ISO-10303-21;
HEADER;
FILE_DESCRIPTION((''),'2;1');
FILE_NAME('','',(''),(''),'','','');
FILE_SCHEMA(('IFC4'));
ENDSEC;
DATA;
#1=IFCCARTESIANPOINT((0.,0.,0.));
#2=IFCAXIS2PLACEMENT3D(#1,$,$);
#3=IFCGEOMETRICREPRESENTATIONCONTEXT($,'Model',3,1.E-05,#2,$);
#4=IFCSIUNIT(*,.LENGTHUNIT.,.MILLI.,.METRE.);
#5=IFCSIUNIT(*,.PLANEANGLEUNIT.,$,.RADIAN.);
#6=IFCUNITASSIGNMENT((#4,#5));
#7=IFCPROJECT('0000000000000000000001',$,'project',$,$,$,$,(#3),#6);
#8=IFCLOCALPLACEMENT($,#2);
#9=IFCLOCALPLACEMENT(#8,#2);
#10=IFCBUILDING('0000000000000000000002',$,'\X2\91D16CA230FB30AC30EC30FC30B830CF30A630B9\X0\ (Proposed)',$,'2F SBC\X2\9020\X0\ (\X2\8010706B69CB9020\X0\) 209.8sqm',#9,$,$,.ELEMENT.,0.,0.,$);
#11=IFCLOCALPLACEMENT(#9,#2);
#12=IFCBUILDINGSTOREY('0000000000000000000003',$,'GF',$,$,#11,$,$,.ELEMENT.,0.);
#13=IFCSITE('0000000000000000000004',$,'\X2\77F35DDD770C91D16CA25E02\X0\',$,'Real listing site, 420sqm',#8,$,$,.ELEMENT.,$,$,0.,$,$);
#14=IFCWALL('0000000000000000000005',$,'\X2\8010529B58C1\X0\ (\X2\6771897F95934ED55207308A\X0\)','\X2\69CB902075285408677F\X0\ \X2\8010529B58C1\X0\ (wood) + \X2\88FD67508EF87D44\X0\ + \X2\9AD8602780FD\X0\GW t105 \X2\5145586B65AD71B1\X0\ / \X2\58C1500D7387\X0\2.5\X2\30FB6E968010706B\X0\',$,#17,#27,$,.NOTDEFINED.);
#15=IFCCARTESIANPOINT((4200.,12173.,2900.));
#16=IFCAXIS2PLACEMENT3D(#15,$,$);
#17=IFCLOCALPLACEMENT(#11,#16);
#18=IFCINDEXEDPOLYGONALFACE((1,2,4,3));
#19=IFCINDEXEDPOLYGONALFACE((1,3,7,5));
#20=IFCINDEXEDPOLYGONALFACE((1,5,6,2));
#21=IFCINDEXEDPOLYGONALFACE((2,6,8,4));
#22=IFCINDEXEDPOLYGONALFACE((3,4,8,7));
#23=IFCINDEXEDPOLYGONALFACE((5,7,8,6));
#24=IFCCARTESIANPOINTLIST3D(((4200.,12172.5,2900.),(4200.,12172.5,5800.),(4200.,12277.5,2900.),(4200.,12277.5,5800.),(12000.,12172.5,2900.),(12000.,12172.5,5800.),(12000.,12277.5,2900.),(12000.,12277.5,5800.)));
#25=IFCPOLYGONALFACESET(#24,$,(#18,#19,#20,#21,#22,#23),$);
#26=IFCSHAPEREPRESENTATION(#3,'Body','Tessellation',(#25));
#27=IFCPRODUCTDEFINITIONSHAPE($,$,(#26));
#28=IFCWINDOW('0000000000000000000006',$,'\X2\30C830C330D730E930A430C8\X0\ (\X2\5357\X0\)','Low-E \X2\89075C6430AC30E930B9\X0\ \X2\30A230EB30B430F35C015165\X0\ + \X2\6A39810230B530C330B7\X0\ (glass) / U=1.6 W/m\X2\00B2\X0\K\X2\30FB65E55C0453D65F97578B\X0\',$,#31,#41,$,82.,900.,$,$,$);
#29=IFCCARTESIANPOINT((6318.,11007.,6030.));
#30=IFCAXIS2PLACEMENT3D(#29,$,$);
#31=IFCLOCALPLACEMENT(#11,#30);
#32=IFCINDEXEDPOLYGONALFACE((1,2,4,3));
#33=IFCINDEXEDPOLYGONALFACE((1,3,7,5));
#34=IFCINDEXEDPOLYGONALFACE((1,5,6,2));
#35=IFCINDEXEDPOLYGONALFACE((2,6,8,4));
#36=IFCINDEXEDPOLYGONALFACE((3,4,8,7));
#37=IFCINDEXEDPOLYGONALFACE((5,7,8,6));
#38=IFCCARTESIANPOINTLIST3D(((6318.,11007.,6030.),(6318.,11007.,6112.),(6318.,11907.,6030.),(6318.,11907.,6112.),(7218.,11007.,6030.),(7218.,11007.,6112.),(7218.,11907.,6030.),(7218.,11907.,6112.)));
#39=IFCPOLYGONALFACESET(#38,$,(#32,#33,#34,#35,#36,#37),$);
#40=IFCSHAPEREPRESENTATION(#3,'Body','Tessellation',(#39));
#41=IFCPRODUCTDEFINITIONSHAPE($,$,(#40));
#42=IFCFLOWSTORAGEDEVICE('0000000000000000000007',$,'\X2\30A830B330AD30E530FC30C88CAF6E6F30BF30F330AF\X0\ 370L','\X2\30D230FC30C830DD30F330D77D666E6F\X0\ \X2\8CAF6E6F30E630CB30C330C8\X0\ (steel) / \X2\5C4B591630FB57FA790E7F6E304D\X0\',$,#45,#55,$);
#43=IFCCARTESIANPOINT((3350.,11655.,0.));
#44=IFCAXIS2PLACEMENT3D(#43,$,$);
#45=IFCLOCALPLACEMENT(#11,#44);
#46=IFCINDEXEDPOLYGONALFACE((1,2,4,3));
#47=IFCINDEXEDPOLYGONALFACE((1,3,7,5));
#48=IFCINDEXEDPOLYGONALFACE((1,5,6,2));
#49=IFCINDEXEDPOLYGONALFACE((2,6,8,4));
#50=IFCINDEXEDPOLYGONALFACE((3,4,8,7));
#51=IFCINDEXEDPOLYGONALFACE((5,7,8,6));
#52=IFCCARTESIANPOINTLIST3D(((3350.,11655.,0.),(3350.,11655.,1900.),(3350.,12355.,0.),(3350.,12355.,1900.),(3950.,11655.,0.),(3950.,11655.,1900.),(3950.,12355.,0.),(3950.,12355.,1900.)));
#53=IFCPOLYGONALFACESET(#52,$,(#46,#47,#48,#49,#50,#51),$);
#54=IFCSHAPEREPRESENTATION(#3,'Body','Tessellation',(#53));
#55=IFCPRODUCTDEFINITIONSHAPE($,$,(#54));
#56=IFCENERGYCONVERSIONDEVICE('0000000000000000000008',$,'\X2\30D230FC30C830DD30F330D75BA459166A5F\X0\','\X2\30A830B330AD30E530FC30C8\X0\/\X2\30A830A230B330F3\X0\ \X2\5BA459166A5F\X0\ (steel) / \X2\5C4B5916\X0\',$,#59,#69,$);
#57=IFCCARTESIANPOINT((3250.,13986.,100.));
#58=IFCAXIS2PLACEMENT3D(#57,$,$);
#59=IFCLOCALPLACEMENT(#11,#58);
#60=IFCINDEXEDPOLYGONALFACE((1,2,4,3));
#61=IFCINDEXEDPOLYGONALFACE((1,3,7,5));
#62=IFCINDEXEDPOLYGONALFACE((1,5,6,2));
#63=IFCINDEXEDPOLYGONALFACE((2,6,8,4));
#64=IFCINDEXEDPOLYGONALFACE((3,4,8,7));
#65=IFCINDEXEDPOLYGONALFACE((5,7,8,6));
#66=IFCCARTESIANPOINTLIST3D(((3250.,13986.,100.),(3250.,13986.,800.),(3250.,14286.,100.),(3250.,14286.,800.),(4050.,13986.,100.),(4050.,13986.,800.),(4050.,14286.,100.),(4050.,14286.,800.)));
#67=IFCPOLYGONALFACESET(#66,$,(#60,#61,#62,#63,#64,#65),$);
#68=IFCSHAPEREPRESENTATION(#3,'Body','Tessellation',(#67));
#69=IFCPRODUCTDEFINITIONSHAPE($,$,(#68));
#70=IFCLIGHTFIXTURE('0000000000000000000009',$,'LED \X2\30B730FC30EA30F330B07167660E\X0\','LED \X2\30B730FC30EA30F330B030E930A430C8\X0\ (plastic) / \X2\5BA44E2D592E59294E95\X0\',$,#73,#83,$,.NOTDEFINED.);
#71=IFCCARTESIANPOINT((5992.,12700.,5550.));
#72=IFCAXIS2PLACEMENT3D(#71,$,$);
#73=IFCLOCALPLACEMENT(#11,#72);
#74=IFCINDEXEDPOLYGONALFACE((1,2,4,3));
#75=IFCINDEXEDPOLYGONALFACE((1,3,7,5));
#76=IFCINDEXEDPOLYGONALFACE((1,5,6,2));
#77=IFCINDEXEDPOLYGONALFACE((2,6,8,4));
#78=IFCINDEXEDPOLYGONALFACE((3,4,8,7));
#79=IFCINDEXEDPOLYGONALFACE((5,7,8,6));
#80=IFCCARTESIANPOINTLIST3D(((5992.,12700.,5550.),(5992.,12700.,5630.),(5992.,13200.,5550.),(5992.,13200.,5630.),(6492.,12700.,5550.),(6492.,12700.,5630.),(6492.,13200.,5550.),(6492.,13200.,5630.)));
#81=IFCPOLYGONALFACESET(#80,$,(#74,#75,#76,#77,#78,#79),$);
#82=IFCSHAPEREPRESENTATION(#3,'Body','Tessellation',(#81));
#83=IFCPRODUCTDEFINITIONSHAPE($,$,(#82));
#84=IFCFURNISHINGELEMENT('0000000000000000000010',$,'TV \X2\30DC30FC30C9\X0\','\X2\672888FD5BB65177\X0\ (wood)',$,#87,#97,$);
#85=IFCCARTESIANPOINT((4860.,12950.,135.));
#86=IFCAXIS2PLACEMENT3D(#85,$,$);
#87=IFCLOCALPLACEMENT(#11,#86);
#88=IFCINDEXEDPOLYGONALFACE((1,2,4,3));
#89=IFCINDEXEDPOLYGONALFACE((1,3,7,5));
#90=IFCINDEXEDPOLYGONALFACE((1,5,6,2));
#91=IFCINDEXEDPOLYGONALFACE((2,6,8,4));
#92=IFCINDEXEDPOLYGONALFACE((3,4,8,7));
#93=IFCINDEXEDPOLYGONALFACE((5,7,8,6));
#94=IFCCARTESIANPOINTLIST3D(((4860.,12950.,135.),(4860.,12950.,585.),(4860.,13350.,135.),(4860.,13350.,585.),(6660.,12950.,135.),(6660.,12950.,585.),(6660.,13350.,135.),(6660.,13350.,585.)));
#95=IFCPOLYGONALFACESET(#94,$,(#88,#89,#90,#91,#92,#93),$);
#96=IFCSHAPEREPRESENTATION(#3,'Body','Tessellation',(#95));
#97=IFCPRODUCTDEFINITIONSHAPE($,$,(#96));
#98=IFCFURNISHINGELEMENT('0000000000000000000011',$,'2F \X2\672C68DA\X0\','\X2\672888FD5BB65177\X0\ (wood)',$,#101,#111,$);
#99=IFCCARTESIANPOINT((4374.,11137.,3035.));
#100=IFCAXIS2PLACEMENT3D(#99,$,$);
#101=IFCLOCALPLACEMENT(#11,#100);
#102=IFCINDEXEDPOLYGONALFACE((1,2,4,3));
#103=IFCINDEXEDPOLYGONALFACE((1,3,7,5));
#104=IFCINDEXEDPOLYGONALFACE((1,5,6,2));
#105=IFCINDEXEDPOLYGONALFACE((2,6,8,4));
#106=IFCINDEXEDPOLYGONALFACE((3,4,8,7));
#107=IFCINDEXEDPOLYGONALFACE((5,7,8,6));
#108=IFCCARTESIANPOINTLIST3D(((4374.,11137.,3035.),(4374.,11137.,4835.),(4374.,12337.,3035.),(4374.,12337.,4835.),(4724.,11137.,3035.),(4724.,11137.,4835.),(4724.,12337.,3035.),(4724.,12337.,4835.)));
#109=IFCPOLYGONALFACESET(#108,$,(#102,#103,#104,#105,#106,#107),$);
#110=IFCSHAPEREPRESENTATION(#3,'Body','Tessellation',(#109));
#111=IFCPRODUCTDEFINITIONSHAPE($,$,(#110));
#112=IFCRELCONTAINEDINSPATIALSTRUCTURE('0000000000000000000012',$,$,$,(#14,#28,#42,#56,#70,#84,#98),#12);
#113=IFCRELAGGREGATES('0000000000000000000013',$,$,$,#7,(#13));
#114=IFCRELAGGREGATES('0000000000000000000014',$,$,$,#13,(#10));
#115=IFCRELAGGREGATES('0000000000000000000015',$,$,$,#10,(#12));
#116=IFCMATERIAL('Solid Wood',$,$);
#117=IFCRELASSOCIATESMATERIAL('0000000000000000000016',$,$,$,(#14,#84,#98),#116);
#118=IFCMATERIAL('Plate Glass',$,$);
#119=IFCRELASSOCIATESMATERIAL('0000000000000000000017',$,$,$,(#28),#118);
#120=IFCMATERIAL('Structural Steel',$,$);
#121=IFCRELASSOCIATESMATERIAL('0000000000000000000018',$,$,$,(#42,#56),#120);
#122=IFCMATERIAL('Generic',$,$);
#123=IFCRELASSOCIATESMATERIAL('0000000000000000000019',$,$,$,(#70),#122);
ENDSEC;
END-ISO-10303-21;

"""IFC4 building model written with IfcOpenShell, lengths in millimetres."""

from ifc_helpers import new_model, si_unit, frame, frame_2d, origin, place, context, project, spatial, rectangle, extrude, material, element, save


model = new_model("IFC4")

# Units and contexts
model_context = context("Model", 3, precision=1e-05, world=origin())
ifc_project = project(units=[si_unit("LENGTHUNIT", "METRE", prefix="MILLI"), si_unit("PLANEANGLEUNIT", "RADIAN")], contexts=[model_context])

# Site, building, storey
site_placement = place(None, origin())
site = spatial("IfcSite", under=ifc_project, at=site_placement, Name="石川県金沢市", ObjectType="Real listing site, 420sqm", CompositionType="ELEMENT", RefElevation=0.0)
building_placement = place(site_placement, origin())
building = spatial("IfcBuilding", under=site, at=building_placement, Name="金沢・ガレージハウス (Proposed)", ObjectType="2F SBC造 (耐火構造) 209.8sqm", CompositionType="ELEMENT", ElevationOfRefHeight=0.0, ElevationOfTerrain=0.0)
storey_placement = place(building_placement, origin())
storey = spatial("IfcBuildingStorey", under=building, at=storey_placement, Name="GF", CompositionType="ELEMENT", Elevation=0.0)

# Shared definitions
ifc_material_1 = material(Name="Solid Wood")

# Wall
wall_1_placement = place(storey_placement, frame((4200.0, 12173.0, 2900.0)))
element("IfcWall", 1, at=wall_1_placement, inside=storey, material=ifc_material_1, Name="耐力壁 (東西間仕切り)", Description="構造用合板 耐力壁 (wood) + 製材軸組 + 高性能GW t105 充填断熱 / 壁倍率2.5・準耐火", PredefinedType="NOTDEFINED", context=model_context, shape_type="SweptSolid", body=[
    extrude(rectangle(XDim=7800.0, YDim=105.0, at=frame_2d((3900.0, 52.0))), frame((4200.0, 12173.0, 2900.0)), (0.0, 0.0, 1.0), 2900.0),
])

# Window
ifc_material_2 = material(Name="Plate Glass")
window_placement = place(storey_placement, frame((6318.0, 11007.0, 6030.0)))
element("IfcWindow", 2, at=window_placement, inside=storey, material=ifc_material_2, Name="トップライト (南)", Description="Low-E 複層ガラス アルゴン封入 + 樹脂サッシ (glass) / U=1.6 W/m²K・日射取得型", OverallHeight=82.0, OverallWidth=900.0, context=model_context, shape_type="SweptSolid", body=[
    extrude(rectangle(XDim=900.0, YDim=900.0, at=frame_2d((450.0, 450.0))), frame((6318.0, 11007.0, 6030.0)), (0.0, 0.0, 1.0), 82.0),
])

# Flow storage device
ifc_material_3 = material(Name="Structural Steel")
flow_storage_device_placement = place(storey_placement, frame((3350.0, 11655.0, 0.0)))
element("IfcFlowStorageDevice", 3, at=flow_storage_device_placement, inside=storey, material=ifc_material_3, Name="エコキュート貯湯タンク 370L", Description="ヒートポンプ給湯 貯湯ユニット (steel) / 屋外・基礎置き", context=model_context, shape_type="SweptSolid", body=[
    extrude(rectangle(XDim=600.0, YDim=700.0, at=frame_2d((300.0, 350.0))), frame((3350.0, 11655.0, 0.0)), (0.0, 0.0, 1.0), 1900.0),
])

# Energy conversion device
energy_conversion_device_placement = place(storey_placement, frame((3250.0, 13986.0, 100.0)))
element("IfcEnergyConversionDevice", 4, at=energy_conversion_device_placement, inside=storey, material=ifc_material_3, Name="ヒートポンプ室外機", Description="エコキュート/エアコン 室外機 (steel) / 屋外", context=model_context, shape_type="SweptSolid", body=[
    extrude(rectangle(XDim=800.0, YDim=300.0, at=frame_2d((400.0, 150.0))), frame((3250.0, 13986.0, 100.0)), (0.0, 0.0, 1.0), 700.0),
])

# Light fixture
ifc_material_4 = material(Name="Generic")
light_fixture_placement = place(storey_placement, frame((5992.0, 12700.0, 5550.0)))
element("IfcLightFixture", 5, at=light_fixture_placement, inside=storey, material=ifc_material_4, Name="LED シーリング照明", Description="LED シーリングライト (plastic) / 室中央天井", PredefinedType="NOTDEFINED", context=model_context, shape_type="SweptSolid", body=[
    extrude(rectangle(XDim=500.0, YDim=500.0, at=frame_2d((250.0, 250.0))), frame((5992.0, 12700.0, 5550.0)), (0.0, 0.0, 1.0), 80.0),
])

# Furnishing elements
furnishing_1_placement = place(storey_placement, frame((4860.0, 12950.0, 135.0)))
element("IfcFurnishingElement", 6, at=furnishing_1_placement, inside=storey, material=ifc_material_1, Name="TV ボード", Description="木製家具 (wood)", context=model_context, shape_type="SweptSolid", body=[
    extrude(rectangle(XDim=1800.0, YDim=400.0, at=frame_2d((900.0, 200.0))), frame((4860.0, 12950.0, 135.0)), (0.0, 0.0, 1.0), 450.0),
])
furnishing_2_placement = place(storey_placement, frame((4374.0, 11137.0, 3035.0)))
element("IfcFurnishingElement", 7, at=furnishing_2_placement, inside=storey, material=ifc_material_1, Name="2F 本棚", Description="木製家具 (wood)", context=model_context, shape_type="SweptSolid", body=[
    extrude(rectangle(XDim=350.0, YDim=1200.0, at=frame_2d((175.0, 600.0))), frame((4374.0, 11137.0, 3035.0)), (0.0, 0.0, 1.0), 1800.0),
])

save(model, "model.ifc")
